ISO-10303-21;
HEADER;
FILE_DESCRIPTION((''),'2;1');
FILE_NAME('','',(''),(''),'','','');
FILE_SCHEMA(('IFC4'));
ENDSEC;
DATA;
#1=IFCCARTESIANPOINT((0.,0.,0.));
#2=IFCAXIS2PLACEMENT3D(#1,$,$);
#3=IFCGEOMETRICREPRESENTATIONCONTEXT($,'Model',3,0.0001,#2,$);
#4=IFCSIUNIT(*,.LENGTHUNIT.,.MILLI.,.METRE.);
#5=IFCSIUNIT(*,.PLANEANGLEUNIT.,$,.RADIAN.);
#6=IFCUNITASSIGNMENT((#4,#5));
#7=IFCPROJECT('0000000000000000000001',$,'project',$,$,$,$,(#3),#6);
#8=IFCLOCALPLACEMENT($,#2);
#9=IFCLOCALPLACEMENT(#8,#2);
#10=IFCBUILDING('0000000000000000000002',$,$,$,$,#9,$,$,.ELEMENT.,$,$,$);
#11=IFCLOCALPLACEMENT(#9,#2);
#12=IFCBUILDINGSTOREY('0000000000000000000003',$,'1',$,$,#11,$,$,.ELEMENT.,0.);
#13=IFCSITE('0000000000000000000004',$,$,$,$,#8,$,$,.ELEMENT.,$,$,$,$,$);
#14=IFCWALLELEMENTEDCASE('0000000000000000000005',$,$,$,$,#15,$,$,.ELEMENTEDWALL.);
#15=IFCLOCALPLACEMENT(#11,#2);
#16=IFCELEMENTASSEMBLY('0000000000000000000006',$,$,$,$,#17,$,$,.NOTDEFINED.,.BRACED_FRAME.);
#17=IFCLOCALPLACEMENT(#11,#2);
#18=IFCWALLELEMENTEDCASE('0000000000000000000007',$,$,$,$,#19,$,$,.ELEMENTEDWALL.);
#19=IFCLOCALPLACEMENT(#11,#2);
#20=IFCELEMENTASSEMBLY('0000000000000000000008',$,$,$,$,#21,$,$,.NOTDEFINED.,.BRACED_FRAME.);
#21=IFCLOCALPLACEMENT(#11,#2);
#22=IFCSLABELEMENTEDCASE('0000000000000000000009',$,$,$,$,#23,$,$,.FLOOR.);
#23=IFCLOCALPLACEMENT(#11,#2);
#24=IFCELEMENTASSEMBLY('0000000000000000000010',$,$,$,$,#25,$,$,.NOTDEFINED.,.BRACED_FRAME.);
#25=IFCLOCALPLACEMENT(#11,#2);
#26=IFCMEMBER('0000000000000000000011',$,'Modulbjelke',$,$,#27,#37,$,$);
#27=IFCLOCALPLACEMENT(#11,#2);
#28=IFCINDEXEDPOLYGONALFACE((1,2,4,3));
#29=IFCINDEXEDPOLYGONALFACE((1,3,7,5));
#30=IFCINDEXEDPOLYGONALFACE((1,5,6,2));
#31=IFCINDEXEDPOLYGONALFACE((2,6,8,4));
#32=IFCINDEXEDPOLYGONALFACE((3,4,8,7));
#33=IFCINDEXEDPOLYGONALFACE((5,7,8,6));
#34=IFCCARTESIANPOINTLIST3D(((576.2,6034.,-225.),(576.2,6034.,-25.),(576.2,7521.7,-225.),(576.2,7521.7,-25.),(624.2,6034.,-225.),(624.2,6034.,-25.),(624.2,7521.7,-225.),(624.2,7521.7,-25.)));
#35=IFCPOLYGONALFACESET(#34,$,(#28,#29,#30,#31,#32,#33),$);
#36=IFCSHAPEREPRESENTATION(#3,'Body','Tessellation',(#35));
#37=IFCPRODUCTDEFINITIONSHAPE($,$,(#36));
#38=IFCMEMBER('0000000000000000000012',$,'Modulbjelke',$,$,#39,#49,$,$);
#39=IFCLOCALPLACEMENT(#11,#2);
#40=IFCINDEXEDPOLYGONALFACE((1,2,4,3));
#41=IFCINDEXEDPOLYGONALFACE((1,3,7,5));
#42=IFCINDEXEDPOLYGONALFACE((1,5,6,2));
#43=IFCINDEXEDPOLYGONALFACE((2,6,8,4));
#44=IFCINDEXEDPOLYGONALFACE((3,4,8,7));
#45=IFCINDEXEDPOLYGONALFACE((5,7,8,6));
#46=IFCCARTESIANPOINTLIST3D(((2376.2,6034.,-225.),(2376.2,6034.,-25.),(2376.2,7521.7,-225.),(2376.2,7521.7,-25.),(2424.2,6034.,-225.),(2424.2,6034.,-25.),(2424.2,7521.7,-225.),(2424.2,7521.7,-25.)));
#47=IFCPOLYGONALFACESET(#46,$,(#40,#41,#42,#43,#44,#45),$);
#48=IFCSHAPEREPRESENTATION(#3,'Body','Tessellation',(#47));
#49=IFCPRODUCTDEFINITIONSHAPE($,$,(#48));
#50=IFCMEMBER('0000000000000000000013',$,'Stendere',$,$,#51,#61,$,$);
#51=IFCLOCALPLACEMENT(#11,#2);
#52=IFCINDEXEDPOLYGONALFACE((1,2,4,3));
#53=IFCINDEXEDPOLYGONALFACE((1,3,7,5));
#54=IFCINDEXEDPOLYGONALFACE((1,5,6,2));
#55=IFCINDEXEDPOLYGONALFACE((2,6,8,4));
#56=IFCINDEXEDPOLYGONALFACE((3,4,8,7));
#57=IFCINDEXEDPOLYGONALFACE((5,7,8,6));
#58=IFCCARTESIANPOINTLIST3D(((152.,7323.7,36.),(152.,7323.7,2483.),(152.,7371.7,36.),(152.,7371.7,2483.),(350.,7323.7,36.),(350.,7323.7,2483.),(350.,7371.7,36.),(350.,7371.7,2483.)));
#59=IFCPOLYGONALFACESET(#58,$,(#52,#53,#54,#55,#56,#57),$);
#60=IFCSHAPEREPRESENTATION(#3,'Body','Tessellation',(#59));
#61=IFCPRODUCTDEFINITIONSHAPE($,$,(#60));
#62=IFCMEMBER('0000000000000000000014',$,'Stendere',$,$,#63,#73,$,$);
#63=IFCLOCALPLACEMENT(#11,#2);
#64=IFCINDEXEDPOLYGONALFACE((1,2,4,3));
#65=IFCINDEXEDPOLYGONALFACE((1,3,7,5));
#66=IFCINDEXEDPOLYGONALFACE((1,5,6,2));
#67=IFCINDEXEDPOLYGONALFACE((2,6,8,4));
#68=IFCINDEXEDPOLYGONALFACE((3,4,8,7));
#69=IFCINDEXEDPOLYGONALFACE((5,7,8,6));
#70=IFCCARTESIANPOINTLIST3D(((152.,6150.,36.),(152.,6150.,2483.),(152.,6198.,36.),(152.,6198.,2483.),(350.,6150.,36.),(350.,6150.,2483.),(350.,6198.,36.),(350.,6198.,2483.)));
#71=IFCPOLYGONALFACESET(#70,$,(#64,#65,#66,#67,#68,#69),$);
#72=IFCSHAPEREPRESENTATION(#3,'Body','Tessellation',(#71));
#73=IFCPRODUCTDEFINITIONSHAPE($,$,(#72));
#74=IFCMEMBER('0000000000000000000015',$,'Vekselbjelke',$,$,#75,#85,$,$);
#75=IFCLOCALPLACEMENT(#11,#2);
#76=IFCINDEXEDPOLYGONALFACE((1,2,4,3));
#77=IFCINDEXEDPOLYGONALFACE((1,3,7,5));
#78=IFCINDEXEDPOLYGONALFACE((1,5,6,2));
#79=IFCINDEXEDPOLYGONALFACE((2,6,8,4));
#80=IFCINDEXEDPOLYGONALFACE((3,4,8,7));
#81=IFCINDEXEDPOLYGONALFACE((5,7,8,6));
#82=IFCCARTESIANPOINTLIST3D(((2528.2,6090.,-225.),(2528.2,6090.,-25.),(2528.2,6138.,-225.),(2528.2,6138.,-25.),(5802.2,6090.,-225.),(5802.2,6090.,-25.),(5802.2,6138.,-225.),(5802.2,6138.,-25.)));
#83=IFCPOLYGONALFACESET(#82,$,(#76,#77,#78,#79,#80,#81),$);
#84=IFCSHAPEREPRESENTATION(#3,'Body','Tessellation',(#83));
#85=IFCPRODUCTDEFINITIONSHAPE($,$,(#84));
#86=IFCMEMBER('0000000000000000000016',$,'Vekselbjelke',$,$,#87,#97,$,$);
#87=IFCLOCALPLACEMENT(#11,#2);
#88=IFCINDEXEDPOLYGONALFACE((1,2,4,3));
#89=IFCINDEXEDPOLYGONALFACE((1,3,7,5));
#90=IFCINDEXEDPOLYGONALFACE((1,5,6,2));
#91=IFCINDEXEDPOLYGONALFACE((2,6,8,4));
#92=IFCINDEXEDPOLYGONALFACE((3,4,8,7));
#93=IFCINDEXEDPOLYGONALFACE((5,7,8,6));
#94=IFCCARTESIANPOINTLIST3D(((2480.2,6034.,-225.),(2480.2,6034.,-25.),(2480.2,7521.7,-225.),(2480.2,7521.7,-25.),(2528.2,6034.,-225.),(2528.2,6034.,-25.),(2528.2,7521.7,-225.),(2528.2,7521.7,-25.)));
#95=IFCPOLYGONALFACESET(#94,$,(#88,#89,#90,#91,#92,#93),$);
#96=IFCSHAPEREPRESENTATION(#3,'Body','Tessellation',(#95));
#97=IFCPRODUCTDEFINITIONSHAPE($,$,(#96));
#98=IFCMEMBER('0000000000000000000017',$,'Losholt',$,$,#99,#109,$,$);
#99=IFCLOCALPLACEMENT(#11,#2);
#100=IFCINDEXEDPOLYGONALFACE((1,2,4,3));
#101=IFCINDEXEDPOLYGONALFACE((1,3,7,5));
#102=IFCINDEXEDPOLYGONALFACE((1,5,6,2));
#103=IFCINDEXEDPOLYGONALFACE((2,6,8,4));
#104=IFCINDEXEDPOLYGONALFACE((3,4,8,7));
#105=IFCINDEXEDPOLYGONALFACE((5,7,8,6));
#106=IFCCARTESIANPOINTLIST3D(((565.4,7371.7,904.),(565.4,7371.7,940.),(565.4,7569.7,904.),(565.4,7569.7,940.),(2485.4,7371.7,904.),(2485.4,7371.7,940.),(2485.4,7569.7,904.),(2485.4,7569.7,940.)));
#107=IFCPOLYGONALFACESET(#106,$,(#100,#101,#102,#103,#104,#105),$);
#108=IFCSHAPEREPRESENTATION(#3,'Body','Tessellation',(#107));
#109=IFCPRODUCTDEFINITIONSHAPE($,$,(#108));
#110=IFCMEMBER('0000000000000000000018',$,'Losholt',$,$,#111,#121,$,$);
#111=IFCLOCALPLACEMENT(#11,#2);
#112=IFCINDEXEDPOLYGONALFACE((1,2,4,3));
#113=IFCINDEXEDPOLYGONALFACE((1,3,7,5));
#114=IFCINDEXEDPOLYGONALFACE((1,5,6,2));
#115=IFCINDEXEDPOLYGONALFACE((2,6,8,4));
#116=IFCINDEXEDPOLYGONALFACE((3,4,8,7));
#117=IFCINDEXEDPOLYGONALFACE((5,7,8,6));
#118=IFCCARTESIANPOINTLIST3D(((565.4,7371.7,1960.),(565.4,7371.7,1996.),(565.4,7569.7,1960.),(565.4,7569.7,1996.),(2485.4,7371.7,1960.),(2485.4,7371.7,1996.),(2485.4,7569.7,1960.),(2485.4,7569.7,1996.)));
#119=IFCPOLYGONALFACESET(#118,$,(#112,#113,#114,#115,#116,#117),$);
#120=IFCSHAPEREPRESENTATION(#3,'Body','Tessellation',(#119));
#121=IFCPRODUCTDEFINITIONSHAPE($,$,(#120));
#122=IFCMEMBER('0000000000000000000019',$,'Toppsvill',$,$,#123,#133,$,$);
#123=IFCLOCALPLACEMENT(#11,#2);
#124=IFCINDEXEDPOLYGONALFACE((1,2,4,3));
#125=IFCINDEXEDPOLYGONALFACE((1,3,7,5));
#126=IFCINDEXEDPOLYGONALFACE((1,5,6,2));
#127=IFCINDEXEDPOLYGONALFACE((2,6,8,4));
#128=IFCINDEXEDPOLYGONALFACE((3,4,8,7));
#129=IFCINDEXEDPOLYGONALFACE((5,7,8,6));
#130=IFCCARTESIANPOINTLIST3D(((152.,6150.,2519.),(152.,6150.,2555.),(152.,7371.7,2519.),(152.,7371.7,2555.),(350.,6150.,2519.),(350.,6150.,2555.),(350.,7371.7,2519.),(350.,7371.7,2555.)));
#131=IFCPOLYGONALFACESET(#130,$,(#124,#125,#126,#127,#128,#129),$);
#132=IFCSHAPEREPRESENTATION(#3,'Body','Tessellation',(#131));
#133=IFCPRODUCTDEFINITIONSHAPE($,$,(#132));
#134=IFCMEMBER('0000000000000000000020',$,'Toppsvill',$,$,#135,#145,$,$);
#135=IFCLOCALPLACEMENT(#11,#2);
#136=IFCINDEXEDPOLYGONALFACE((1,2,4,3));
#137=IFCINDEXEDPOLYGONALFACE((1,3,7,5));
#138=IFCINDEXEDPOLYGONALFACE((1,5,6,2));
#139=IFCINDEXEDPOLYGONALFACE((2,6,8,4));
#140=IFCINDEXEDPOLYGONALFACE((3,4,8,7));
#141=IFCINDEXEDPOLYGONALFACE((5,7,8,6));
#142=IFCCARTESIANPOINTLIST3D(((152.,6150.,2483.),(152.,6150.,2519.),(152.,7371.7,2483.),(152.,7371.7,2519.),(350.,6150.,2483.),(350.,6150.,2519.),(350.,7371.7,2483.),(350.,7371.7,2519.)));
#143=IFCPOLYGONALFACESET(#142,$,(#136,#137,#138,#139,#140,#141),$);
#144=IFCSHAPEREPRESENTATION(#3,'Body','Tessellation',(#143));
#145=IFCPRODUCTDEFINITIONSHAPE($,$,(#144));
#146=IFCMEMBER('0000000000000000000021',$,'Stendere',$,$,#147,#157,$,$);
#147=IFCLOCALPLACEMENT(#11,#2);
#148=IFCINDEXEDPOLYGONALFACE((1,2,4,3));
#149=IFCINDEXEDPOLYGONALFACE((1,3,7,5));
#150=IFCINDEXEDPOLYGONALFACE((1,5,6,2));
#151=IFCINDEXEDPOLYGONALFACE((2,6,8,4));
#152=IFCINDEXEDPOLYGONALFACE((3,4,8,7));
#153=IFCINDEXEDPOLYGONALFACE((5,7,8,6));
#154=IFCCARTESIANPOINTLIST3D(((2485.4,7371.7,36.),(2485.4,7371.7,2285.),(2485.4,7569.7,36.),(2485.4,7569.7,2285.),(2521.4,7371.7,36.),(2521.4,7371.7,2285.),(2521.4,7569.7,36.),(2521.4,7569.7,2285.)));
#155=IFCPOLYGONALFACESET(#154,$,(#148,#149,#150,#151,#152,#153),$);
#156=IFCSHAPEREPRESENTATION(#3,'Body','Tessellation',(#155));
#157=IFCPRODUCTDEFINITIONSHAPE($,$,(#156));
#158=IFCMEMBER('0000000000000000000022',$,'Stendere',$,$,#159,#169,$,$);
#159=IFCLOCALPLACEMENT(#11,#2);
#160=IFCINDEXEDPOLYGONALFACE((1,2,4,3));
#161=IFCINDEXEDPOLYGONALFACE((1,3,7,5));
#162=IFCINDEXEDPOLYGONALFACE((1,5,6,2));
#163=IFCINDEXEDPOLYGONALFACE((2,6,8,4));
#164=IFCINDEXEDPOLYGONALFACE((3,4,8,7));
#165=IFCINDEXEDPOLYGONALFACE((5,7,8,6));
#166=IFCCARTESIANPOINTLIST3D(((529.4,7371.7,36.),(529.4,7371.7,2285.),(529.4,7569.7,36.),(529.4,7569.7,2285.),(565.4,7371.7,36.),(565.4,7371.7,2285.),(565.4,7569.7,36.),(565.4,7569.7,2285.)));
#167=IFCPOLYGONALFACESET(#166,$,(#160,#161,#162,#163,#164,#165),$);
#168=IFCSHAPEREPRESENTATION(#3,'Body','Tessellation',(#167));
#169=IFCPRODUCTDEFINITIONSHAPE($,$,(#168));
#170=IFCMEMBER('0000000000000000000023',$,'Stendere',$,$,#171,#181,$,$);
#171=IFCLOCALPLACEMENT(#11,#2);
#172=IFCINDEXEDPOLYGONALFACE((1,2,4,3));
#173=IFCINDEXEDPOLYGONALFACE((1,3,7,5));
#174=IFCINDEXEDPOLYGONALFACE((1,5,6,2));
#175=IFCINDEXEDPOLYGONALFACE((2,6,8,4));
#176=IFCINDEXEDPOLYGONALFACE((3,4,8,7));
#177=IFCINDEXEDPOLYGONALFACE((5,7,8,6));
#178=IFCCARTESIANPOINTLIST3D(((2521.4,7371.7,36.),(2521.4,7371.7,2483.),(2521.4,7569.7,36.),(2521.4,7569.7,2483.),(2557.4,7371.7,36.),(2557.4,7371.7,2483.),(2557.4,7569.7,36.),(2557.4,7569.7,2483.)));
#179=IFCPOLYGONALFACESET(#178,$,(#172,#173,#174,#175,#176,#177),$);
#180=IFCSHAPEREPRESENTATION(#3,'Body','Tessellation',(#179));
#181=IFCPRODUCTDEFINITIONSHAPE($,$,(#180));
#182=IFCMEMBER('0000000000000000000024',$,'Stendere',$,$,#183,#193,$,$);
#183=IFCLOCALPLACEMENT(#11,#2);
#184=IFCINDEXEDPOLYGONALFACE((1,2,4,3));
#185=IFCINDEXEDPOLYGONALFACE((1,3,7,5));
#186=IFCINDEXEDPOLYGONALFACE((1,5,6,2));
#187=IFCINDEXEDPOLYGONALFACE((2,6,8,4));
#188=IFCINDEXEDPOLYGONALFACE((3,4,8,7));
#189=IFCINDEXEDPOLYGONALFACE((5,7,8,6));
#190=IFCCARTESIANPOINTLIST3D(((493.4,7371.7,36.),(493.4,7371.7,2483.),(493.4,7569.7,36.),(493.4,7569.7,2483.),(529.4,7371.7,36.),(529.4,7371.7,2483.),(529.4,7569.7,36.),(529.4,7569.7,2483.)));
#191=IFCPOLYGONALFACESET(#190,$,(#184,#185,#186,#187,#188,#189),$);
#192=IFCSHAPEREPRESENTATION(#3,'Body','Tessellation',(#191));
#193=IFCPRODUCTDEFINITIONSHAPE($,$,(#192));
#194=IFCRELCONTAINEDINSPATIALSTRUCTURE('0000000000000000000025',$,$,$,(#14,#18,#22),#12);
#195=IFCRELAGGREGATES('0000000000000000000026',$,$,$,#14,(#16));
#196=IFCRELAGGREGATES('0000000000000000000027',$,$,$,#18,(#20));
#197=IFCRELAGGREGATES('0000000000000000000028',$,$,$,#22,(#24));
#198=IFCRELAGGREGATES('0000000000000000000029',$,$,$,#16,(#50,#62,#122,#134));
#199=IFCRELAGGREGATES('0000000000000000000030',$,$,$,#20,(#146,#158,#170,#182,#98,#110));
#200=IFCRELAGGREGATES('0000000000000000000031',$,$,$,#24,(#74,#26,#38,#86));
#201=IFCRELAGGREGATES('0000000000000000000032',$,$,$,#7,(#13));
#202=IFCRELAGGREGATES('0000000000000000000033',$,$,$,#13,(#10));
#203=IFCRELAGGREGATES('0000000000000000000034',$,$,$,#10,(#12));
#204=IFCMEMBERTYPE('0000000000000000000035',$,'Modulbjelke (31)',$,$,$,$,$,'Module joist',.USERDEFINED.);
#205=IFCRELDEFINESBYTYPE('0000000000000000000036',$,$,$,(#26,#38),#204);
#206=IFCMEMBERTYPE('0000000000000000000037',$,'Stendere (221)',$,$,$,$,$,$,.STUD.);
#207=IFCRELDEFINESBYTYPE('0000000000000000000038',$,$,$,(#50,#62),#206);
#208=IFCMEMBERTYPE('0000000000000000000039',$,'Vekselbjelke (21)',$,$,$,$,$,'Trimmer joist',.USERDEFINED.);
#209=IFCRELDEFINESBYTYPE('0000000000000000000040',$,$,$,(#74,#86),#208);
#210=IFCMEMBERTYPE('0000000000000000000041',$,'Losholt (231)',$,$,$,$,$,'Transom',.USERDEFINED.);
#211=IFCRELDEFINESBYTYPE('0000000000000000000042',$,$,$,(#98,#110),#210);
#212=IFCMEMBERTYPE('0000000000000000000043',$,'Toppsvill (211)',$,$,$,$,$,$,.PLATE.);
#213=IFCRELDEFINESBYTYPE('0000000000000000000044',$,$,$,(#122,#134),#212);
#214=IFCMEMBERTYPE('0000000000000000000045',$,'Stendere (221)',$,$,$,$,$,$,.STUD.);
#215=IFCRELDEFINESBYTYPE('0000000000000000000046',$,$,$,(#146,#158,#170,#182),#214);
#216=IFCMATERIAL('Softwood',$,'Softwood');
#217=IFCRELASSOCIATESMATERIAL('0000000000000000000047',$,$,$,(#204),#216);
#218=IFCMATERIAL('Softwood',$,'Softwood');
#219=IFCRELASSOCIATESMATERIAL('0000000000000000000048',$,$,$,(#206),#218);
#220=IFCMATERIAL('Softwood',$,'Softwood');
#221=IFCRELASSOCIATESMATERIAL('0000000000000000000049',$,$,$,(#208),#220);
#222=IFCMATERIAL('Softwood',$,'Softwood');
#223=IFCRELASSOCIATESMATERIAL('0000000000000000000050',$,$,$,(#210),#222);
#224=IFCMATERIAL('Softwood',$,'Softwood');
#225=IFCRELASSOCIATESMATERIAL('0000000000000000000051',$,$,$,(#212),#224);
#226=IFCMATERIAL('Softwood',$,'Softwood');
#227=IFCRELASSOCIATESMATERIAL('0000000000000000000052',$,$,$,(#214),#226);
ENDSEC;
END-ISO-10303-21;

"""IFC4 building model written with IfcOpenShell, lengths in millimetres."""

from ifc_helpers import new_model, si_unit, frame, origin, place, context, project, spatial, rectangle, extrude, clip, halfspace, material, material_profile, profile_set, type_object, element, aggregate, save


model = new_model("IFC4")

# Units and contexts
model_context = context("Model", 3, precision=0.0001, world=origin())
ifc_project = project(units=[si_unit("LENGTHUNIT", "METRE", prefix="MILLI"), si_unit("PLANEANGLEUNIT", "RADIAN")], contexts=[model_context])

# Site, building, storey
site_placement = place(None, origin())
site = spatial("IfcSite", under=ifc_project, at=site_placement, CompositionType="ELEMENT")
building_placement = place(site_placement, origin())
building = spatial("IfcBuilding", under=site, at=building_placement, CompositionType="ELEMENT")
storey_placement = place(building_placement, origin())
storey = spatial("IfcBuildingStorey", under=building, at=storey_placement, Name="1", CompositionType="ELEMENT", Elevation=0.0)

# Walls, element assemblies
wall_1_placement = place(storey_placement, frame((350.0, 7371.7, 0.0), z_axis=(-1.0, 0.0, 0.0), x_axis=(0.0, -1.0, 0.0)))
wall_1 = element("IfcWallElementedCase", 1, at=wall_1_placement, inside=storey, PredefinedType="ELEMENTEDWALL")
assembly_1_placement = place(wall_1_placement, origin())
assembly_1 = element("IfcElementAssembly", 2, at=assembly_1_placement, AssemblyPlace="NOTDEFINED", PredefinedType="BRACED_FRAME")
aggregate(wall_1, [assembly_1])
wall_2_placement = place(storey_placement, frame((5348.2, 7371.7, 0.0), z_axis=(0.0, 1.0, 0.0), x_axis=(-1.0, 0.0, 0.0)))
wall_2 = element("IfcWallElementedCase", 3, at=wall_2_placement, inside=storey, PredefinedType="ELEMENTEDWALL")
assembly_2_placement = place(wall_2_placement, origin())
assembly_2 = element("IfcElementAssembly", 4, at=assembly_2_placement, AssemblyPlace="NOTDEFINED", PredefinedType="BRACED_FRAME")
aggregate(wall_2, [assembly_2])

# Slab, element assembly, members
slab_placement = place(storey_placement, origin())
slab = element("IfcSlabElementedCase", 5, at=slab_placement, inside=storey, PredefinedType="FLOOR")
assembly_3_placement = place(slab_placement, frame((0.0, 0.0, -225.0)))
assembly_3 = element("IfcElementAssembly", 6, at=assembly_3_placement, AssemblyPlace="NOTDEFINED", PredefinedType="BRACED_FRAME")
aggregate(slab, [assembly_3])
ifc_material_1 = material(Name="Softwood", Category="Softwood")
ifc_material_profile_1 = material_profile(ifc_material_1, rectangle(XDim=48.0, YDim=200.0), Name="Modulbjelke (31)")
ifc_profile_set_1 = profile_set([ifc_material_profile_1])
member_type_1 = type_object("IfcMemberType", Name="Modulbjelke (31)", ElementType="Module joist", PredefinedType="USERDEFINED", material=ifc_profile_set_1)
member_1_placement = place(assembly_3_placement, frame((600.2, 6034.0, 0.0), z_axis=(0.000001, 1.0, 0.0), x_axis=(-1.0, 0.000001, 0.0)))
member_1 = element("IfcMember", 7, at=member_1_placement, type_object=member_type_1, Name="Modulbjelke", context=model_context, shape_type="Clipping", body=[
    clip(clip(extrude(rectangle(XDim=48.0, YDim=200.0), frame((0.0, 100.0, 0.0)), (0.0, 0.0, 1.0), 1487.7), halfspace(frame((0.0, 100.0, 0.0)), True)), halfspace(frame((0.0, 100.0, 1487.7)), False)),
])
member_2_placement = place(assembly_3_placement, frame((2400.2, 6034.0, 0.0), z_axis=(0.000001, 1.0, 0.0), x_axis=(-1.0, 0.000001, 0.0)))
member_2 = element("IfcMember", 8, at=member_2_placement, type_object=member_type_1, Name="Modulbjelke", context=model_context, shape_type="Clipping", body=[
    clip(clip(extrude(rectangle(XDim=48.0, YDim=200.0), frame((0.0, 100.0, 0.0)), (0.0, 0.0, 1.0), 1487.7), halfspace(frame((0.0, 100.0, 0.0)), True)), halfspace(frame((0.0, 100.0, 1487.7)), False)),
])

# Members
ifc_material_2 = material(Name="Softwood", Category="Softwood")
ifc_material_profile_2 = material_profile(ifc_material_2, rectangle(XDim=48.0, YDim=198.0), Name="Stendere (221)")
ifc_profile_set_2 = profile_set([ifc_material_profile_2])
member_type_2 = type_object("IfcMemberType", Name="Stendere (221)", PredefinedType="STUD", material=ifc_profile_set_2)
member_3_placement = place(assembly_1_placement, frame((24.0, 36.0, 0.0), z_axis=(0.0, 1.0, 0.0), x_axis=(-1.0, 0.0, 0.0)))
member_3 = element("IfcMember", 9, at=member_3_placement, type_object=member_type_2, Name="Stendere", context=model_context, shape_type="SweptSolid", body=[
    extrude(rectangle(XDim=48.0, YDim=198.0), frame((0.0, 99.0, 0.0)), (0.0, 0.0, 1.0), 2447.0),
])
member_4_placement = place(assembly_1_placement, frame((1197.7, 36.0, 0.0), z_axis=(0.0, 1.0, 0.0), x_axis=(-1.0, 0.0, 0.0)))
member_4 = element("IfcMember", 10, at=member_4_placement, type_object=member_type_2, Name="Stendere", context=model_context, shape_type="SweptSolid", body=[
    extrude(rectangle(XDim=48.0, YDim=198.0), frame((0.0, 99.0, 0.0)), (0.0, 0.0, 1.0), 2447.0),
])
ifc_material_3 = material(Name="Softwood", Category="Softwood")
ifc_material_profile_3 = material_profile(ifc_material_3, rectangle(XDim=48.0, YDim=200.0), Name="Vekselbjelke (21)")
ifc_profile_set_3 = profile_set([ifc_material_profile_3])
member_type_3 = type_object("IfcMemberType", Name="Vekselbjelke (21)", ElementType="Trimmer joist", PredefinedType="USERDEFINED", material=ifc_profile_set_3)
member_5_placement = place(assembly_3_placement, frame((2528.2, 6114.0, 0.0), z_axis=(1.0, 0.0, 0.0), x_axis=(0.0, 1.0, 0.0)))
member_5 = element("IfcMember", 11, at=member_5_placement, type_object=member_type_3, Name="Vekselbjelke", context=model_context, shape_type="SweptSolid", body=[
    extrude(rectangle(XDim=48.0, YDim=200.0), frame((0.0, 100.0, 0.0)), (0.0, 0.0, 1.0), 3274.0),
])
member_6_placement = place(assembly_3_placement, frame((2504.2, 7521.7, 0.0), z_axis=(0.0, -1.0, 0.0)))
member_6 = element("IfcMember", 12, at=member_6_placement, type_object=member_type_3, Name="Vekselbjelke", context=model_context, shape_type="SweptSolid", body=[
    extrude(rectangle(XDim=48.0, YDim=200.0), frame((0.0, 100.0, 0.0)), (0.0, 0.0, 1.0), 1487.7),
])
ifc_material_4 = material(Name="Softwood", Category="Softwood")
ifc_material_profile_4 = material_profile(ifc_material_4, rectangle(XDim=36.0, YDim=198.0), Name="Losholt (231)")
ifc_profile_set_4 = profile_set([ifc_material_profile_4])
member_type_4 = type_object("IfcMemberType", Name="Losholt (231)", ElementType="Transom", PredefinedType="USERDEFINED", material=ifc_profile_set_4)
member_7_placement = place(assembly_2_placement, frame((2862.7, 922.0, 0.0), z_axis=(1.0, 0.0, 0.0), x_axis=(0.0, 1.0, 0.0)))
member_7 = element("IfcMember", 13, at=member_7_placement, type_object=member_type_4, Name="Losholt", context=model_context, shape_type="SweptSolid", body=[
    extrude(rectangle(XDim=36.0, YDim=198.0), frame((0.0, 99.0, 0.0)), (0.0, 0.0, 1.0), 1920.0),
])
member_8_placement = place(assembly_2_placement, frame((2862.7, 1978.0, 0.0), z_axis=(1.0, 0.0, 0.0), x_axis=(0.0, 1.0, 0.0)))
member_8 = element("IfcMember", 14, at=member_8_placement, type_object=member_type_4, Name="Losholt", context=model_context, shape_type="SweptSolid", body=[
    extrude(rectangle(XDim=36.0, YDim=198.0), frame((0.0, 99.0, 0.0)), (0.0, 0.0, 1.0), 1920.0),
])
ifc_material_5 = material(Name="Softwood", Category="Softwood")
ifc_material_profile_5 = material_profile(ifc_material_5, rectangle(XDim=36.0, YDim=198.0), Name="Toppsvill (211)")
ifc_profile_set_5 = profile_set([ifc_material_profile_5])
member_type_5 = type_object("IfcMemberType", Name="Toppsvill (211)", PredefinedType="PLATE", material=ifc_profile_set_5)
member_9_placement = place(assembly_1_placement, frame((0.0, 2537.0, 0.0), z_axis=(1.0, 0.0, 0.0), x_axis=(0.0, 1.0, 0.0)))
member_9 = element("IfcMember", 15, at=member_9_placement, type_object=member_type_5, Name="Toppsvill", context=model_context, shape_type="Clipping", body=[
    clip(extrude(rectangle(XDim=36.0, YDim=198.0), frame((0.0, 99.0, 0.0)), (0.0, 0.0, 1.0), 1221.7), halfspace(frame((0.0, 99.0, 0.0)), True)),
])
member_10_placement = place(assembly_1_placement, frame((0.0, 2501.0, 0.0), z_axis=(1.0, 0.0, 0.0), x_axis=(0.0, 1.0, 0.0)))
member_10 = element("IfcMember", 16, at=member_10_placement, type_object=member_type_5, Name="Toppsvill", context=model_context, shape_type="Clipping", body=[
    clip(extrude(rectangle(XDim=36.0, YDim=198.0), frame((0.0, 99.0, 0.0)), (0.0, 0.0, 1.0), 1221.7), halfspace(frame((0.0, 99.0, 0.0)), True)),
])
aggregate(assembly_1, [member_3, member_4, member_9, member_10])
ifc_material_6 = material(Name="Softwood", Category="Softwood")
ifc_material_profile_6 = material_profile(ifc_material_6, rectangle(XDim=36.0, YDim=198.0), Name="Stendere (221)")
ifc_profile_set_6 = profile_set([ifc_material_profile_6])
member_type_6 = type_object("IfcMemberType", Name="Stendere (221)", PredefinedType="STUD", material=ifc_profile_set_6)
member_11_placement = place(assembly_2_placement, frame((2844.7, 36.0, 0.0), z_axis=(0.0, 1.0, 0.0), x_axis=(-1.0, 0.0, 0.0)))
member_11 = element("IfcMember", 17, at=member_11_placement, type_object=member_type_6, Name="Stendere", context=model_context, shape_type="SweptSolid", body=[
    extrude(rectangle(XDim=36.0, YDim=198.0), frame((0.0, 99.0, 0.0)), (0.0, 0.0, 1.0), 2249.0),
])
member_12_placement = place(assembly_2_placement, frame((4800.7, 36.0, 0.0), z_axis=(0.0, 1.0, 0.0), x_axis=(-1.0, 0.0, 0.0)))
member_12 = element("IfcMember", 18, at=member_12_placement, type_object=member_type_6, Name="Stendere", context=model_context, shape_type="SweptSolid", body=[
    extrude(rectangle(XDim=36.0, YDim=198.0), frame((0.0, 99.0, 0.0)), (0.0, 0.0, 1.0), 2249.0),
])
member_13_placement = place(assembly_2_placement, frame((2808.7, 36.0, 0.0), z_axis=(0.0, 1.0, 0.0), x_axis=(-1.0, 0.0, 0.0)))
member_13 = element("IfcMember", 19, at=member_13_placement, type_object=member_type_6, Name="Stendere", context=model_context, shape_type="SweptSolid", body=[
    extrude(rectangle(XDim=36.0, YDim=198.0), frame((0.0, 99.0, 0.0)), (0.0, 0.0, 1.0), 2447.0),
])
member_14_placement = place(assembly_2_placement, frame((4836.7, 36.0, 0.0), z_axis=(0.0, 1.0, 0.0), x_axis=(-1.0, 0.0, 0.0)))
member_14 = element("IfcMember", 20, at=member_14_placement, type_object=member_type_6, Name="Stendere", context=model_context, shape_type="SweptSolid", body=[
    extrude(rectangle(XDim=36.0, YDim=198.0), frame((0.0, 99.0, 0.0)), (0.0, 0.0, 1.0), 2447.0),
])

aggregate(assembly_2, [member_11, member_12, member_13, member_14, member_7, member_8])
aggregate(assembly_3, [member_5, member_1, member_2, member_6])

save(model, "model.ifc")
